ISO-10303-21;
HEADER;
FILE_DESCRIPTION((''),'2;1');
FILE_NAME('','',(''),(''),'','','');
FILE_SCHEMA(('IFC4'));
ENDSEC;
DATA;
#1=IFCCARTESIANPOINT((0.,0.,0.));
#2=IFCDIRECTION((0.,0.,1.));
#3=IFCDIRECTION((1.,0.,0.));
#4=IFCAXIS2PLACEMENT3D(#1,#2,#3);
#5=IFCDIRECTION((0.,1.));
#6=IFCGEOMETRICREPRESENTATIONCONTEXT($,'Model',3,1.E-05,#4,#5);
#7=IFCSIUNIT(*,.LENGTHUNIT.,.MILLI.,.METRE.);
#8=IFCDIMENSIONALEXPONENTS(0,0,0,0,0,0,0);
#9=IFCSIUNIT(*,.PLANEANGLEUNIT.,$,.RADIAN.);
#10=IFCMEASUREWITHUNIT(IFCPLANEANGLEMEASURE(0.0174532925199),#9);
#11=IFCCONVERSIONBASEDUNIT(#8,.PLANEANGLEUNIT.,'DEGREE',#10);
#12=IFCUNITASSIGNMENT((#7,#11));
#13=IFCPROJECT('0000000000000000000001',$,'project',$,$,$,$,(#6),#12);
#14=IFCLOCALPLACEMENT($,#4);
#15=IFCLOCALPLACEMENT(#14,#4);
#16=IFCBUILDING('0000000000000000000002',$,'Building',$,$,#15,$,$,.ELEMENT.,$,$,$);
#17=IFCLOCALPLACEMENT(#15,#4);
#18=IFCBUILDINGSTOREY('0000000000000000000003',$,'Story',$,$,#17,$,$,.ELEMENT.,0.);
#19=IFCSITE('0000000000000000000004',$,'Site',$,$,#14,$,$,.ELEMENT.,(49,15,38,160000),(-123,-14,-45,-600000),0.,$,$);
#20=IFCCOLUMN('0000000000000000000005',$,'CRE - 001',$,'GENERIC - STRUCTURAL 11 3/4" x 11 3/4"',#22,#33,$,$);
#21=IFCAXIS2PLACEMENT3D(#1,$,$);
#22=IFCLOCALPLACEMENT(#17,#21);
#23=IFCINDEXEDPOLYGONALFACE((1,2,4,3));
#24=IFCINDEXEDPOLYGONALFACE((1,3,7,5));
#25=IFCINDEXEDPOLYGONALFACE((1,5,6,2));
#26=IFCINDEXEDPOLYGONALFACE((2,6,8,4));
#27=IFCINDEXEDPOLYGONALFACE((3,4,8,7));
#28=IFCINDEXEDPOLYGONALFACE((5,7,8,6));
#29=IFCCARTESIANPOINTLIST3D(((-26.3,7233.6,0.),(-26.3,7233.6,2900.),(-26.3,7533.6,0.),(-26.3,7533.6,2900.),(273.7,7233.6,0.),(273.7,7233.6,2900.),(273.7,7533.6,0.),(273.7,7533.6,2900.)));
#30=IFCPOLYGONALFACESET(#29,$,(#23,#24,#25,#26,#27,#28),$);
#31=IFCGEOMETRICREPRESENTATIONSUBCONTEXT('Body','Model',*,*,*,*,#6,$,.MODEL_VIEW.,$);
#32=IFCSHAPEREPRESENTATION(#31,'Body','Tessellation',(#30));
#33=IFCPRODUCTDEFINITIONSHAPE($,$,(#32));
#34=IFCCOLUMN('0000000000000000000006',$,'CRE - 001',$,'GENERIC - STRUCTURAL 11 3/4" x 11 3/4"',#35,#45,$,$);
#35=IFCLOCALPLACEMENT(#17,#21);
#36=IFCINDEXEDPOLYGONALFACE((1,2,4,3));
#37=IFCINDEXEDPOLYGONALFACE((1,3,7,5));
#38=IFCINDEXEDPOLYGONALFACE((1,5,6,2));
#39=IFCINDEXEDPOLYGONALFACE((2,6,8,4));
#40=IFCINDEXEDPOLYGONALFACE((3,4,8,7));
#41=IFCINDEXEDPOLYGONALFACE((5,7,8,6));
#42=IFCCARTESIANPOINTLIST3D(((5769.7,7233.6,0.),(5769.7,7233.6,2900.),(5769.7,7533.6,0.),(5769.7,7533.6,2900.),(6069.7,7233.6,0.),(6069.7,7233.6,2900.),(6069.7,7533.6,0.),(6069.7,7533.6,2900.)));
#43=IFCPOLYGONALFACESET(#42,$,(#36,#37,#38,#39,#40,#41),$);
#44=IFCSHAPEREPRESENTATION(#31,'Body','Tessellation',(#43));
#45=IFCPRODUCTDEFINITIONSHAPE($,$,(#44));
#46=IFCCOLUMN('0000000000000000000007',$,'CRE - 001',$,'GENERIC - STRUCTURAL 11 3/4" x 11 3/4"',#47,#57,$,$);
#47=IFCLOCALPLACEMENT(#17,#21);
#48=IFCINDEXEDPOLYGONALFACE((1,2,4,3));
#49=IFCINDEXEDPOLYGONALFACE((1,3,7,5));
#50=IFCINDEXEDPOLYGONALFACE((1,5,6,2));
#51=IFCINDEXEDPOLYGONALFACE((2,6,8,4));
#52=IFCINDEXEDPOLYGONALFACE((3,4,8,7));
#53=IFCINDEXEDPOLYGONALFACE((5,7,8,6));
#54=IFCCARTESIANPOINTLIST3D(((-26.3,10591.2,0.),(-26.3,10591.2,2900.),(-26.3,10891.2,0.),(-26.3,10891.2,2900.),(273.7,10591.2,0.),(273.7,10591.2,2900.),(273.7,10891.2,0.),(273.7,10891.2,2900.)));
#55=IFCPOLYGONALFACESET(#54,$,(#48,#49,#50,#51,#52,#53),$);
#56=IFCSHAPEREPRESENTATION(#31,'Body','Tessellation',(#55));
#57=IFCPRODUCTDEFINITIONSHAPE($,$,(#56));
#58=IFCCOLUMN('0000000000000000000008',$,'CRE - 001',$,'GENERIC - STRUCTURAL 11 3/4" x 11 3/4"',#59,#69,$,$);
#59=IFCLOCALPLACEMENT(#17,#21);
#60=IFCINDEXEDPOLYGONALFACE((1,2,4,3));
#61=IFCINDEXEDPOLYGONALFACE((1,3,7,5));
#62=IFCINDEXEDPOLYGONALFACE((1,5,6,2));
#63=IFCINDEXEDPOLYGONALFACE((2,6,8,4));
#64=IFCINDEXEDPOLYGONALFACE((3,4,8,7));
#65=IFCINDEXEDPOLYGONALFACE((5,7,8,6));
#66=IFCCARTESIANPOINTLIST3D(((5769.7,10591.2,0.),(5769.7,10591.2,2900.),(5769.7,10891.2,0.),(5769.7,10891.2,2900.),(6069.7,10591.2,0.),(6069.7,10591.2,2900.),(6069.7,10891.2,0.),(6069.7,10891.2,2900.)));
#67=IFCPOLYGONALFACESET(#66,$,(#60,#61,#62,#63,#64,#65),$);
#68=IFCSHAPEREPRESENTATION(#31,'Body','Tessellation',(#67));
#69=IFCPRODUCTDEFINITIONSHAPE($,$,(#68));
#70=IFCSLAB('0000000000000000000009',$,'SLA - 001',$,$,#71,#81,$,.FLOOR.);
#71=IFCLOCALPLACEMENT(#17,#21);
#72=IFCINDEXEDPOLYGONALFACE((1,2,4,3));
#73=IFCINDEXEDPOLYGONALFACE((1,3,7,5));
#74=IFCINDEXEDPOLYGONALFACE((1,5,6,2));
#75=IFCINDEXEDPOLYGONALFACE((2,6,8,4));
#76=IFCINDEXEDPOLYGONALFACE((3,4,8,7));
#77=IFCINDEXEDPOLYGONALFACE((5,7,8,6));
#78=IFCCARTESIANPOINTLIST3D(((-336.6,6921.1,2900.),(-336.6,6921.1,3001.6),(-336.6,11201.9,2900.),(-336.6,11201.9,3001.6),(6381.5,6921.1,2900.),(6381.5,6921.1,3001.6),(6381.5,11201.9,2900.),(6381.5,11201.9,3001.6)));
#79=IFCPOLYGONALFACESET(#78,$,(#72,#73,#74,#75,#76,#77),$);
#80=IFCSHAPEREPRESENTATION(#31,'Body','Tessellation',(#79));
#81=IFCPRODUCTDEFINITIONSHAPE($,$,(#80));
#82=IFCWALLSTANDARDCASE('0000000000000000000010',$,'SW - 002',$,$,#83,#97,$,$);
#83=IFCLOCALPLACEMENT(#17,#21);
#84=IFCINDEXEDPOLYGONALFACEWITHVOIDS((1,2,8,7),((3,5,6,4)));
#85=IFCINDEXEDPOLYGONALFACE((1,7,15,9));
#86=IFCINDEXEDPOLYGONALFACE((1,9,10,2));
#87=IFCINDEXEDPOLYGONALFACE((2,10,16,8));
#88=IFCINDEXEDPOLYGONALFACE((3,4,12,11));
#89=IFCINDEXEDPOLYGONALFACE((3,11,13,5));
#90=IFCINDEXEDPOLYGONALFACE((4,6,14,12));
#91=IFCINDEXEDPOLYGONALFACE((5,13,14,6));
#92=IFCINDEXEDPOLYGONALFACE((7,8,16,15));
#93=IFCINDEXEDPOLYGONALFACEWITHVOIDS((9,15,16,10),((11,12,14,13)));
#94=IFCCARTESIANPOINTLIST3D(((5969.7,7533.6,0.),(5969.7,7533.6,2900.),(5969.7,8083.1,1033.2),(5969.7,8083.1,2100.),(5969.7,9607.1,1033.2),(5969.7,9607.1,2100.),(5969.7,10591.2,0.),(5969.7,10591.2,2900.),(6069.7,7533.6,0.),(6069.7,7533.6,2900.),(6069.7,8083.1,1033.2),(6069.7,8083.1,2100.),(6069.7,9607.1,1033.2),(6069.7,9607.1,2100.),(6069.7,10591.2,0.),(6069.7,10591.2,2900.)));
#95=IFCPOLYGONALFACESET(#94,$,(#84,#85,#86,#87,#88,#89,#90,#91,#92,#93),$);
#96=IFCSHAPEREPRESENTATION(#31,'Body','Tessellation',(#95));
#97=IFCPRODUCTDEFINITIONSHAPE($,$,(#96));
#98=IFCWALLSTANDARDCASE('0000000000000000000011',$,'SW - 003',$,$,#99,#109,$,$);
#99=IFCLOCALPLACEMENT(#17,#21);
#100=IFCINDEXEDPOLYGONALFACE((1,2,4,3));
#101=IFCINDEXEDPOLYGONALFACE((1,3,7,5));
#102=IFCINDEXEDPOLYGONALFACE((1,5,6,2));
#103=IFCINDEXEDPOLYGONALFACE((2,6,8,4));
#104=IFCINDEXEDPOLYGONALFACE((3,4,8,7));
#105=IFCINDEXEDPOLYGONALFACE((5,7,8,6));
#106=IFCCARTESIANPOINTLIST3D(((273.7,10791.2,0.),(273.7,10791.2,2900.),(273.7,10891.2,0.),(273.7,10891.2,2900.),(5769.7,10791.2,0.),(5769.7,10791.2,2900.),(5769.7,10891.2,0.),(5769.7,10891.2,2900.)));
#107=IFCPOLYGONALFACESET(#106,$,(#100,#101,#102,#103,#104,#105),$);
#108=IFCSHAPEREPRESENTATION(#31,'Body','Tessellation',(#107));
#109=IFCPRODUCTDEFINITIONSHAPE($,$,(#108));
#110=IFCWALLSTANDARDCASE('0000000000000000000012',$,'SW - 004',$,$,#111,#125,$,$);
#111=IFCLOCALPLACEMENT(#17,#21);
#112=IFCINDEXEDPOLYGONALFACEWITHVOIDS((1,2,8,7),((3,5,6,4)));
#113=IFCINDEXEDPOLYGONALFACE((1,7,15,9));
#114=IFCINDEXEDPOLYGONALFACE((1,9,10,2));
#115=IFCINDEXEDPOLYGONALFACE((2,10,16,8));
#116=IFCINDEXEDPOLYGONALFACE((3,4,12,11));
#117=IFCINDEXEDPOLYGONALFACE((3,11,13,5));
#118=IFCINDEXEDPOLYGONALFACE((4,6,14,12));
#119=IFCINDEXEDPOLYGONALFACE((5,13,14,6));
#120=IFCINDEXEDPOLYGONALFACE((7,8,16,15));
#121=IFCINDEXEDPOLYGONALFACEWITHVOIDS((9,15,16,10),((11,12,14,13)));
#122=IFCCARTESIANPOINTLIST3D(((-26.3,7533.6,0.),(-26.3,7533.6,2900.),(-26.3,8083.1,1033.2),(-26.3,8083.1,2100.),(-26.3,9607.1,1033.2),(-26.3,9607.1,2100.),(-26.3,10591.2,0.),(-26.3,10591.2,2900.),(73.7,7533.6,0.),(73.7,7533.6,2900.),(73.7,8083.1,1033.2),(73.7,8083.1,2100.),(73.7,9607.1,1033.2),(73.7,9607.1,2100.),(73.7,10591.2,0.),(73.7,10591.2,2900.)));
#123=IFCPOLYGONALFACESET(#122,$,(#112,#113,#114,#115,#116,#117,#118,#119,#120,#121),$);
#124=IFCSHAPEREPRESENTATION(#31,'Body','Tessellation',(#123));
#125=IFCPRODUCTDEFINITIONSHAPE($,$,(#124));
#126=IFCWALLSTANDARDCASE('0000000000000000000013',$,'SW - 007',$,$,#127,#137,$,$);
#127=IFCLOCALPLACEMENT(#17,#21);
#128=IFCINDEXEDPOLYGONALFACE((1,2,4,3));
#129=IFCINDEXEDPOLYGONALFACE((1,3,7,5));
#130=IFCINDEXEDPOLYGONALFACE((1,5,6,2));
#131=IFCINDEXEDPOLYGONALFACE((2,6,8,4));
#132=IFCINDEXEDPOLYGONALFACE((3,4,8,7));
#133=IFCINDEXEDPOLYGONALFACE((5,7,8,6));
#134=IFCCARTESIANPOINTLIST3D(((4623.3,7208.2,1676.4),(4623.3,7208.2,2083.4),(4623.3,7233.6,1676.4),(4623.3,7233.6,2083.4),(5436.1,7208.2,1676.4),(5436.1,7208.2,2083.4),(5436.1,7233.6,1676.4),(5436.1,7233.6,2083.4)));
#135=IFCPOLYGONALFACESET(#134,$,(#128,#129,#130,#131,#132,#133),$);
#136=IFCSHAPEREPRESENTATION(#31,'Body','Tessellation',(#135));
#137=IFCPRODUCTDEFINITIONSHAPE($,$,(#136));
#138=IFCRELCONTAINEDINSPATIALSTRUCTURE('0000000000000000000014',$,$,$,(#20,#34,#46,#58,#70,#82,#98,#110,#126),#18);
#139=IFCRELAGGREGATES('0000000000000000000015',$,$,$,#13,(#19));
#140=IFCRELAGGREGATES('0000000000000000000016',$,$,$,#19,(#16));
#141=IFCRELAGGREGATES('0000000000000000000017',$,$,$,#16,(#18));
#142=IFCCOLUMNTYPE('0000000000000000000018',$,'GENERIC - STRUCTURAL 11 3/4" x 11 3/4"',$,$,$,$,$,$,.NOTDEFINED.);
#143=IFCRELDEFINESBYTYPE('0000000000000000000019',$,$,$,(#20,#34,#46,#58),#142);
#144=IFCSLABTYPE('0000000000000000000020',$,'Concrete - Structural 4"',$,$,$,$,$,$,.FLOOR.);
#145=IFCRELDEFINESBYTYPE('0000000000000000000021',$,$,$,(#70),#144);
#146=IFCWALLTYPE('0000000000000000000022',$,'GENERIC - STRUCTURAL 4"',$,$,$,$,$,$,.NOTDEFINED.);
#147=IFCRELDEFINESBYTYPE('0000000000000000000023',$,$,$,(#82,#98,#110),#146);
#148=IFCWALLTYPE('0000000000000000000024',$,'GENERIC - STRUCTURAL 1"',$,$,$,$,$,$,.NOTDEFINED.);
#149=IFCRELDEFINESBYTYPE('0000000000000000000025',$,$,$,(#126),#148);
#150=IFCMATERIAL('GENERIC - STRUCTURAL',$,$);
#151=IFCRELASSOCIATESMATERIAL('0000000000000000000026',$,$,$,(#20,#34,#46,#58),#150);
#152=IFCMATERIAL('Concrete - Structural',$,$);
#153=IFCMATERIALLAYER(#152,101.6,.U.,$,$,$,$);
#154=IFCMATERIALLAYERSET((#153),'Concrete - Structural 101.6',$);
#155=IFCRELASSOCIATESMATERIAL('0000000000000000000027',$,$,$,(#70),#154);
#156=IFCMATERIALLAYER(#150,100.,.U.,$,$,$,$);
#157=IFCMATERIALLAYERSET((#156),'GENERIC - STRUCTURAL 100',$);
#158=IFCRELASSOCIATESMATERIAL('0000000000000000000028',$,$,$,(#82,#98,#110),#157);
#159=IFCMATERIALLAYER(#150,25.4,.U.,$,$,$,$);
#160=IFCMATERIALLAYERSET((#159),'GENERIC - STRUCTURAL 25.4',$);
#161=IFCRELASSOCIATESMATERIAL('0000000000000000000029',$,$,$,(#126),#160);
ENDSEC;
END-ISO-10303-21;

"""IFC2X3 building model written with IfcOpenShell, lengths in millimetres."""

from ifc_helpers import new_model, entity, si_unit, converted_unit, direction, frame, origin_with_axes, origin_2d_with_axis, place, context, subcontext, project, spatial, polyline, rectangle, outline, extrude, material, layer, layer_set, layer_usage, type_object, element, save


model = new_model("IFC2X3")

# Units and contexts
model_context = context("Model", 3, precision=1e-05, world=origin_with_axes(), true_north=direction((0.0, 1.0)))
body_context = subcontext(model_context, "Body", "Model", "MODEL_VIEW")
ifc_project = project(units=[si_unit("LENGTHUNIT", "METRE", prefix="MILLI"), converted_unit("PLANEANGLEUNIT", "DEGREE", entity("IfcPlaneAngleMeasure", 0.0174532925199), si_unit("PLANEANGLEUNIT", "RADIAN"), dimensions=[0, 0, 0, 0, 0, 0, 0])], contexts=[model_context])

# Site, building, storey
site_placement = place(None, origin_with_axes())
site = spatial("IfcSite", under=ifc_project, at=site_placement, Name="Site", CompositionType="ELEMENT", RefLatitude=(49, 15, 38, 160000), RefLongitude=(-123, -14, -45, -600000), RefElevation=0.0)
building_placement = place(site_placement, origin_with_axes())
building = spatial("IfcBuilding", under=site, at=building_placement, Name="Building", CompositionType="ELEMENT")
storey_placement = place(building_placement, origin_with_axes())
storey = spatial("IfcBuildingStorey", under=building, at=storey_placement, Name="Story", CompositionType="ELEMENT", Elevation=0.0)

# Columns
ifc_material_1 = material(Name="GENERIC - STRUCTURAL")
column_type = type_object("IfcColumnType", Name="GENERIC - STRUCTURAL 11 3/4\" x 11 3/4\"", PredefinedType="NOTDEFINED")
for number, where, z_axis, x_axis, name in (
    (1, (123.7, 7383.6, 0.0), (0.0, 0.0, 1.0), (1.0, 0.0, 0.0), "CRE - 001"),
    (2, (5919.7, 7383.6, 0.0), (0.0, 0.0, 1.0), (1.0, 0.0, 0.0), "CRE - 001"),
    (3, (123.7, 10741.2, 0.0), (0.0, 0.0, 1.0), (1.0, 0.0, 0.0), "CRE - 001"),
    (4, (5919.7, 10741.2, 0.0), (0.0, 0.0, 1.0), (1.0, 0.0, 0.0), "CRE - 001"),
):
    element("IfcColumn", number, at=place(storey_placement, frame(where, z_axis=z_axis, x_axis=x_axis)), inside=storey, type_object=column_type, material=ifc_material_1, Name=name, ObjectType="GENERIC - STRUCTURAL 11 3/4\" x 11 3/4\"", context=body_context, shape_type="SweptSolid", body=[
        extrude(rectangle(XDim=300.0, YDim=300.0, at=origin_2d_with_axis()), origin_with_axes(), (0.0, 0.0, 1.0), 2900.0),
    ])

# Slab
ifc_material_2 = material(Name="Concrete - Structural")
ifc_layer_1 = layer(ifc_material_2, 101.6, ventilated="UNKNOWN")
ifc_layer_set_1 = layer_set([ifc_layer_1], Name="Concrete - Structural 101.6")
ifc_layer_usage_1 = layer_usage(ifc_layer_set_1, "AXIS3", "NEGATIVE", 101.6)
slab_type = type_object("IfcSlabType", Name="Concrete - Structural 4\"", PredefinedType="FLOOR")
slab_placement = place(storey_placement, frame((-336.6, 6921.1, 3001.6), z_axis=(0.0, 0.0, 1.0), x_axis=(1.0, 0.0, 0.0)))
element("IfcSlab", 5, at=slab_placement, inside=storey, type_object=slab_type, material=ifc_layer_usage_1, Name="SLA - 001", PredefinedType="FLOOR", context=body_context, shape_type="SweptSolid", body=[
    extrude(outline(polyline([(0.0, 0.0), (6718.1, 0.0), (6718.1, 4280.8), (0.0, 4280.8), (0.0, 0.0)])), frame((0.0, 0.0, -101.6), z_axis=(0.0, 0.0, 1.0), x_axis=(1.0, 0.0, 0.0)), (0.0, 0.0, 1.0), 101.6),
])

# Wall, opening
ifc_layer_2 = layer(ifc_material_1, 100.0, ventilated="UNKNOWN")
ifc_layer_set_2 = layer_set([ifc_layer_2], Name="GENERIC - STRUCTURAL 100")
wall_type_1 = type_object("IfcWallType", Name="GENERIC - STRUCTURAL 4\"", PredefinedType="NOTDEFINED")
ifc_layer_usage_2 = layer_usage(ifc_layer_set_2, "AXIS2", "POSITIVE", 0.0)
wall_1_placement = place(storey_placement, frame((6069.7, 7533.6, 0.0), z_axis=(0.0, 0.0, 1.0), x_axis=(0.0, 1.0, 0.0)))
wall_1 = element("IfcWallStandardCase", 6, at=wall_1_placement, inside=storey, type_object=wall_type_1, material=ifc_layer_usage_2, Name="SW - 002", context=body_context, shape_type="SweptSolid", body=[
    extrude(outline(polyline([(0.0, 0.0), (3057.6, 0.0), (3057.6, 100.0), (0.0, 100.0), (0.0, 0.0)])), origin_with_axes(), (0.0, 0.0, 1.0), 2900.0),
])
opening_1_placement = place(wall_1_placement, frame((1311.5, 0.0, 1033.2), z_axis=(0.0, 0.0, 1.0), x_axis=(1.0, 0.0, 0.0)))
element("IfcOpeningElement", 7, at=opening_1_placement, cuts=wall_1, context=body_context, shape_type="SweptSolid", body=[
    extrude(rectangle(XDim=1524.0, YDim=1066.8, at=origin_2d_with_axis()), frame((0.0, 200.0, 533.4), z_axis=(0.0, 1.0, 0.0), x_axis=(-1.0, 0.0, 0.0)), (0.0, 0.0, -1.0), 300.0),
])

# Wall
ifc_layer_usage_3 = layer_usage(ifc_layer_set_2, "AXIS2", "POSITIVE", 0.0)
wall_2_placement = place(storey_placement, frame((5769.7, 10891.2, 0.0), z_axis=(0.0, 0.0, 1.0), x_axis=(-1.0, 0.0, 0.0)))
element("IfcWallStandardCase", 8, at=wall_2_placement, inside=storey, type_object=wall_type_1, material=ifc_layer_usage_3, Name="SW - 003", context=body_context, shape_type="SweptSolid", body=[
    extrude(outline(polyline([(0.0, 0.0), (5496.0, 0.0), (5496.0, 100.0), (0.0, 100.0), (0.0, 0.0)])), origin_with_axes(), (0.0, 0.0, 1.0), 2900.0),
])

# Wall, opening
ifc_layer_usage_4 = layer_usage(ifc_layer_set_2, "AXIS2", "POSITIVE", 0.0)
wall_3_placement = place(storey_placement, frame((-26.3, 10591.2, 0.0), z_axis=(0.0, 0.0, 1.0), x_axis=(0.0, -1.0, 0.0)))
wall_3 = element("IfcWallStandardCase", 9, at=wall_3_placement, inside=storey, type_object=wall_type_1, material=ifc_layer_usage_4, Name="SW - 004", context=body_context, shape_type="SweptSolid", body=[
    extrude(outline(polyline([(0.0, 0.0), (3057.6, 0.0), (3057.6, 100.0), (0.0, 100.0), (0.0, 0.0)])), origin_with_axes(), (0.0, 0.0, 1.0), 2900.0),
])
opening_2_placement = place(wall_3_placement, frame((1746.1, 0.0, 1033.2), z_axis=(0.0, 0.0, 1.0), x_axis=(1.0, 0.0, 0.0)))
element("IfcOpeningElement", 10, at=opening_2_placement, cuts=wall_3, context=body_context, shape_type="SweptSolid", body=[
    extrude(rectangle(XDim=1524.0, YDim=1066.8, at=origin_2d_with_axis()), frame((0.0, 200.0, 533.4), z_axis=(0.0, 1.0, 0.0), x_axis=(-1.0, 0.0, 0.0)), (0.0, 0.0, -1.0), 300.0),
])

# Wall
ifc_layer_3 = layer(ifc_material_1, 25.4, ventilated="UNKNOWN")
ifc_layer_set_3 = layer_set([ifc_layer_3], Name="GENERIC - STRUCTURAL 25.4")
ifc_layer_usage_5 = layer_usage(ifc_layer_set_3, "AXIS2", "POSITIVE", 0.0)
wall_type_2 = type_object("IfcWallType", Name="GENERIC - STRUCTURAL 1\"", PredefinedType="NOTDEFINED")
wall_4_placement = place(storey_placement, frame((5436.1, 7233.6, 1676.4), z_axis=(0.0, 0.0, 1.0), x_axis=(-1.0, 0.0, 0.0)))
element("IfcWallStandardCase", 11, at=wall_4_placement, inside=storey, type_object=wall_type_2, material=ifc_layer_usage_5, Name="SW - 007", context=body_context, shape_type="SweptSolid", body=[
    extrude(outline(polyline([(0.0, 0.0), (812.8, 0.0), (812.8, 25.4), (0.0, 25.4), (0.0, 0.0)])), origin_with_axes(), (0.0, 0.0, 1.0), 407.0),
])

save(model, "model.ifc")
